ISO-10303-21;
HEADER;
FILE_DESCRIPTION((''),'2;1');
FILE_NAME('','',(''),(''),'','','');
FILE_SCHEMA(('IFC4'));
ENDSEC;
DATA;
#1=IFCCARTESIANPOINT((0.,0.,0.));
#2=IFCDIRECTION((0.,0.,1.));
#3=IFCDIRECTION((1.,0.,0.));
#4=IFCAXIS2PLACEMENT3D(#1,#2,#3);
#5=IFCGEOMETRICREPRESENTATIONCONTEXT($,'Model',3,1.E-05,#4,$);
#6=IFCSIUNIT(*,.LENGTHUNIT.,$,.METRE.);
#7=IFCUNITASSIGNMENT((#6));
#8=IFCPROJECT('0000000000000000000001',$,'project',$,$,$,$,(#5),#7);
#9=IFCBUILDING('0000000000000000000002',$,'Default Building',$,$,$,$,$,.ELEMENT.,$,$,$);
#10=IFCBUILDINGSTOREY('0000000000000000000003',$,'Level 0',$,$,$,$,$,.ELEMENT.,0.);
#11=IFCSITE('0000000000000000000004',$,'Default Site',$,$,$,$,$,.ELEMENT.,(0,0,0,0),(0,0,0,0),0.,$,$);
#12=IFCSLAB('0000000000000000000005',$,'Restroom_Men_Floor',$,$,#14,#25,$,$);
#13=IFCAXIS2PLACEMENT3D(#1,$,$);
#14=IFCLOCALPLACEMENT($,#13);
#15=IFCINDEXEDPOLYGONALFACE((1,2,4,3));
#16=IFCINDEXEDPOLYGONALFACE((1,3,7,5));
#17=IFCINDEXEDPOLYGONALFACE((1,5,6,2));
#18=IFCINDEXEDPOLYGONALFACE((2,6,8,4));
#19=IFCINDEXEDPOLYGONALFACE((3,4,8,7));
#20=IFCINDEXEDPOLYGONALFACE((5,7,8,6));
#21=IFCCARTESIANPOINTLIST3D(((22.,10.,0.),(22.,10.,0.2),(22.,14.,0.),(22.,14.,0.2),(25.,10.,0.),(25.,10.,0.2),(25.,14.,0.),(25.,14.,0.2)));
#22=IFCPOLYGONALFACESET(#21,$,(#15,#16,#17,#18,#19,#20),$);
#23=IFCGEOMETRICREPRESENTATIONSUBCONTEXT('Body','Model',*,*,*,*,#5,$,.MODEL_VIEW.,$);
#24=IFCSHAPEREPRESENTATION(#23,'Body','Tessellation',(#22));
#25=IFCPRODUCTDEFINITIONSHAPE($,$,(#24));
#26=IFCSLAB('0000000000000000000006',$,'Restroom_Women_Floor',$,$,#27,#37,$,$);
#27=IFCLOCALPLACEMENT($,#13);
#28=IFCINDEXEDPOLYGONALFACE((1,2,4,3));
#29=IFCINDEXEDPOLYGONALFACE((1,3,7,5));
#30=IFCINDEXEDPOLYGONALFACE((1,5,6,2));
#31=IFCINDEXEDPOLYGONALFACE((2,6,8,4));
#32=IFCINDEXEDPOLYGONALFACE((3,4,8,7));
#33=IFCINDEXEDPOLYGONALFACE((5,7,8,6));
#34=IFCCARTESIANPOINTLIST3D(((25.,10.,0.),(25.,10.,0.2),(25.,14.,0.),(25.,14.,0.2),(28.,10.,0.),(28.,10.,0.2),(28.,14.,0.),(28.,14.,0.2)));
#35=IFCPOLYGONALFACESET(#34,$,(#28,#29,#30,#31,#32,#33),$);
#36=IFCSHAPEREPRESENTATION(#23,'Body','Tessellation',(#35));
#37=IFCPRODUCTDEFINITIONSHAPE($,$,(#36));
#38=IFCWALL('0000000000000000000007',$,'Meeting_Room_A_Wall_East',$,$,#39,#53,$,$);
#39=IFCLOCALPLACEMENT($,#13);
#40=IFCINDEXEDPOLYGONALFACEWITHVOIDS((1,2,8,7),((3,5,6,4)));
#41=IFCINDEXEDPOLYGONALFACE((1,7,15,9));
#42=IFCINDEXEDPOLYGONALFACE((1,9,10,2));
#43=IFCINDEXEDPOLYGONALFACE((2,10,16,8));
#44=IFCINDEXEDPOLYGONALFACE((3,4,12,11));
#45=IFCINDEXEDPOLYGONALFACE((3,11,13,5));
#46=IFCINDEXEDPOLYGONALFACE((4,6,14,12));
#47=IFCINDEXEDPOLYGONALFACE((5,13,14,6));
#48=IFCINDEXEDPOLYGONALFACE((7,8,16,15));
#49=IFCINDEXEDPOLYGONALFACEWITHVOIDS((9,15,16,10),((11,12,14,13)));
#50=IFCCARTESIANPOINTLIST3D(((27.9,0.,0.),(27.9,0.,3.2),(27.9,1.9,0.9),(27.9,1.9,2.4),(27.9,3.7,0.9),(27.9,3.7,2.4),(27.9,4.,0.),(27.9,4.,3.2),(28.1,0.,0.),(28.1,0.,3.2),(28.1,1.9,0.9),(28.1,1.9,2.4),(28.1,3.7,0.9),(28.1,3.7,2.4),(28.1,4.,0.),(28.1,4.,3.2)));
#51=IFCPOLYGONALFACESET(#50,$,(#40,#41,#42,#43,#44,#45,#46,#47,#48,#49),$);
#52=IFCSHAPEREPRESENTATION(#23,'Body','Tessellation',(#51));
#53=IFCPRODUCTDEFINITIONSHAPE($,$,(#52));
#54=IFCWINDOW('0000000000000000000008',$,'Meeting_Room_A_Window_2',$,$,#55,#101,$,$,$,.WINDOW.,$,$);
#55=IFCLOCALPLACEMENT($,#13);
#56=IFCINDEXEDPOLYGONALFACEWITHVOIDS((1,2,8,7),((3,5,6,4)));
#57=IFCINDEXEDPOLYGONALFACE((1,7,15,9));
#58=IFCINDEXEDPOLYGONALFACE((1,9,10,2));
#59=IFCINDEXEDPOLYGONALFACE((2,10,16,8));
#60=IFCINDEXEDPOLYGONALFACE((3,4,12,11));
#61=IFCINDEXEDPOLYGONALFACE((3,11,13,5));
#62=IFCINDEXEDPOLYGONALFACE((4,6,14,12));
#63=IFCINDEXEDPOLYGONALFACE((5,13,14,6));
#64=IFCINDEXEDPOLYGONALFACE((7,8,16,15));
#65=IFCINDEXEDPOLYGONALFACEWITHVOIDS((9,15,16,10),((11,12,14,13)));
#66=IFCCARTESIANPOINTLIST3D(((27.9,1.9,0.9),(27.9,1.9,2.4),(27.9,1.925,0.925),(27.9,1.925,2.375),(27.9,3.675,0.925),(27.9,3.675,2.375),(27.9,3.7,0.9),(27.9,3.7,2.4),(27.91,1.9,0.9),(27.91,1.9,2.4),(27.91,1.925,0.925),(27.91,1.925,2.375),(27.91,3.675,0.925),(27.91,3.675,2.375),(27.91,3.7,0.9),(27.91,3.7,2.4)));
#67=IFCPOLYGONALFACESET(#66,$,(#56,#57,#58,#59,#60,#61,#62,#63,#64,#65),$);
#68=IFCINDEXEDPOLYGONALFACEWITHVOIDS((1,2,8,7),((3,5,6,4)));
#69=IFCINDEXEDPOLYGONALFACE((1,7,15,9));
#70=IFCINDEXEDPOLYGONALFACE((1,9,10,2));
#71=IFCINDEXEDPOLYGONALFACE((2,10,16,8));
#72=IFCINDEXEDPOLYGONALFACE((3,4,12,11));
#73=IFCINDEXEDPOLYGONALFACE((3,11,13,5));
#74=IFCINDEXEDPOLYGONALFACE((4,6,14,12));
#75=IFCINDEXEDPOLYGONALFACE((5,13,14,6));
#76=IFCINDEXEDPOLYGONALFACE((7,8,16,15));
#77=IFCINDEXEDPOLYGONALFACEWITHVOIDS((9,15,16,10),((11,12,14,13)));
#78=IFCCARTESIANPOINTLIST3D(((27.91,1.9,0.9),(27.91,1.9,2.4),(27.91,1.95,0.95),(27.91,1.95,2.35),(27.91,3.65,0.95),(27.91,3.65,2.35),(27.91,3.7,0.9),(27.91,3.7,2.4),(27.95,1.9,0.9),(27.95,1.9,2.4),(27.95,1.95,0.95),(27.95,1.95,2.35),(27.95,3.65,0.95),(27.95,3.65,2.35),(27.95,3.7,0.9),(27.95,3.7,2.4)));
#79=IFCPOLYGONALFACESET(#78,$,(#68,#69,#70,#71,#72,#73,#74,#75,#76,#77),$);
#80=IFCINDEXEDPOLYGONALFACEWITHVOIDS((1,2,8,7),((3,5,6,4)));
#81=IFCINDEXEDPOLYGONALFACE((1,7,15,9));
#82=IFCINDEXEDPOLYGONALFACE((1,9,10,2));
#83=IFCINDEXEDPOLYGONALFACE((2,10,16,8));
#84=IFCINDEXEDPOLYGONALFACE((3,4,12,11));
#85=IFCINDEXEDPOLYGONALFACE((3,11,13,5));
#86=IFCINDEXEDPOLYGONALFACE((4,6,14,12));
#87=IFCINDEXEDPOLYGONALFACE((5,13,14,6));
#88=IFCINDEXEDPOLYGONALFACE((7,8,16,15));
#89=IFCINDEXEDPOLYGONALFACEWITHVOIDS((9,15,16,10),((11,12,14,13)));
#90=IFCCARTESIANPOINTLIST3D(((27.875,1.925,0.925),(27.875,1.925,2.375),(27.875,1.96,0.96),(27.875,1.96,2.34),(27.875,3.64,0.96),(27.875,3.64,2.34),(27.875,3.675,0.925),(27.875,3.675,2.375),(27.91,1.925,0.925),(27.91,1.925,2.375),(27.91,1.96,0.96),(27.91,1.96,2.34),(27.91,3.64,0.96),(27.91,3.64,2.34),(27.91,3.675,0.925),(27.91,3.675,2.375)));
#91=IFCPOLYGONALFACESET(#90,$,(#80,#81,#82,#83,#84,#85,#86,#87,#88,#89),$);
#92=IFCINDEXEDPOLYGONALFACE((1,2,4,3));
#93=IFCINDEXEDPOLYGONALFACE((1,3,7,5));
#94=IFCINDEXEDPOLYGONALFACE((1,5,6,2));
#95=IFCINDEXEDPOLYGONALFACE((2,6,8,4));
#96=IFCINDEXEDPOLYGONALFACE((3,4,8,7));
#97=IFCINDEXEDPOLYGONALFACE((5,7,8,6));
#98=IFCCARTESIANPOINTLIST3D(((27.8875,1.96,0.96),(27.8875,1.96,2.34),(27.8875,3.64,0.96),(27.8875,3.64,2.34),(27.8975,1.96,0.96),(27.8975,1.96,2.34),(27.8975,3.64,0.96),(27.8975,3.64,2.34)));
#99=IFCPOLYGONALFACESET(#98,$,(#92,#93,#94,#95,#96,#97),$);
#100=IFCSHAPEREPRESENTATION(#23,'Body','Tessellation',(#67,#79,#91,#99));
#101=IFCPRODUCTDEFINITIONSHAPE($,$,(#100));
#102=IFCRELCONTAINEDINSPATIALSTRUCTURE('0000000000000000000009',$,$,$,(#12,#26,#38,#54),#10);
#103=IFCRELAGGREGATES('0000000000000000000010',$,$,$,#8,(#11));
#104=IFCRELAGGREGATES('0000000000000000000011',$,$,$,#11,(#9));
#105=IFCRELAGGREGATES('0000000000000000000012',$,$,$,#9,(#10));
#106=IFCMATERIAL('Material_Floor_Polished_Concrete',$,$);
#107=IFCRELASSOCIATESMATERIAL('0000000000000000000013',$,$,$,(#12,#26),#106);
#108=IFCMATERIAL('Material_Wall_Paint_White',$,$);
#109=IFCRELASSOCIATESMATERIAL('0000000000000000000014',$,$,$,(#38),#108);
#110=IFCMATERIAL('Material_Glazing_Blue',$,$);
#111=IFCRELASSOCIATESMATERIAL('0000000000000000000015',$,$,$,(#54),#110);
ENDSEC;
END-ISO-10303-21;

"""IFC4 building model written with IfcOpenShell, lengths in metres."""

from ifc_helpers import new_model, si_unit, frame, origin_with_axes, place, context, subcontext, project, spatial, line, indexed_curve, outline, extrude, material, element, fill, save


model = new_model("IFC4")

# Units and contexts
model_context = context("Model", 3, precision=1e-05, world=origin_with_axes())
body_context = subcontext(model_context, "Body", "Model", "MODEL_VIEW")
ifc_project = project(units=[si_unit("LENGTHUNIT", "METRE")], contexts=[model_context])

# Site, building, storey
site = spatial("IfcSite", under=ifc_project, Name="Default Site", CompositionType="ELEMENT", RefLatitude=(0, 0, 0, 0), RefLongitude=(0, 0, 0, 0), RefElevation=0.0)
building = spatial("IfcBuilding", under=site, Name="Default Building", CompositionType="ELEMENT")
storey = spatial("IfcBuildingStorey", under=building, Name="Level 0", CompositionType="ELEMENT", Elevation=0.0)

# Slabs
ifc_material_1 = material(Name="Material_Floor_Polished_Concrete")
for number, where, z_axis, x_axis, name in (
    (1, (22.0, 10.0, 0.0), (0.0, 0.0, 1.0), (1.0, 0.0, 0.0), "Restroom_Men_Floor"),
    (2, (25.0, 10.0, 0.0), (0.0, 0.0, 1.0), (1.0, 0.0, 0.0), "Restroom_Women_Floor"),
):
    element("IfcSlab", number, at=place(None, frame(where, z_axis=z_axis, x_axis=x_axis)), inside=storey, material=ifc_material_1, Name=name, context=body_context, shape_type="SweptSolid", body=[
        extrude(outline(indexed_curve([(0.0, 0.0), (3.0, 0.0), (3.0, 4.0), (0.0, 4.0)])), None, (0.0, 0.0, 1.0), 0.2),
    ])

# Wall, opening, window
ifc_material_2 = material(Name="Material_Wall_Paint_White")
wall_1_placement = place(None, frame((28.0, 0.0, 0.0), z_axis=(0.0, 0.0, 1.0), x_axis=(0.0, 1.0, 0.0)))
wall_1 = element("IfcWall", 3, at=wall_1_placement, inside=storey, material=ifc_material_2, Name="Meeting_Room_A_Wall_East", context=body_context, shape_type="SweptSolid", body=[
    extrude(outline(indexed_curve([(0.0, 0.0), (0.0, 0.2), (4.0, 0.2), (4.0, 0.0), (0.0, 0.0)], self_intersect=False)), frame((0.0, -0.1, 0.0), z_axis=(0.0, 0.0, 1.0), x_axis=(1.0, 0.0, 0.0)), (0.0, 0.0, 1.0), 3.2),
])
opening_1_placement = place(wall_1_placement, frame((1.9, -0.5, 0.9), z_axis=(0.0, 0.0, 1.0), x_axis=(1.0, 0.0, 0.0)))
opening_1 = element("IfcOpeningElement", 4, at=opening_1_placement, inside=storey, cuts=wall_1, PredefinedType="OPENING", context=body_context, shape_type="SweptSolid", body=[
    extrude(outline(indexed_curve([(0.0, 0.0), (0.0, 1.0), (1.8, 1.0), (1.8, 0.0), (0.0, 0.0)], self_intersect=False)), origin_with_axes(), (0.0, 0.0, 1.0), 1.5),
])
ifc_material_3 = material(Name="Material_Glazing_Blue")
window_1_placement = place(None, frame((28.0, 1.9, 0.9), z_axis=(0.0, 0.0, 1.0), x_axis=(0.0, 1.0, 0.0)))
window_1 = element("IfcWindow", 5, at=window_1_placement, inside=storey, material=ifc_material_3, Name="Meeting_Room_A_Window_2", PredefinedType="WINDOW", context=body_context, shape_type="SweptSolid", body=[
    extrude(outline(indexed_curve([(0.0, 0.0), (1.8, 0.0), (1.8, 1.5), (0.0, 1.5)], segments=[line(1, 2, 3, 4, 1)]), holes=[indexed_curve([(0.025, 0.025), (1.775, 0.025), (1.775, 1.475), (0.025, 1.475)], segments=[line(1, 2, 3, 4, 1)])]), frame((0.0, 0.09, 0.0), z_axis=(0.0, -1.0, 0.0), x_axis=(1.0, 0.0, 0.0)), (0.0, 0.0, -1.0), 0.01),
    extrude(outline(indexed_curve([(0.0, 0.0), (1.8, 0.0), (1.8, 1.5), (0.0, 1.5)], segments=[line(1, 2, 3, 4, 1)]), holes=[indexed_curve([(0.05, 0.05), (1.75, 0.05), (1.75, 1.45), (0.05, 1.45)], segments=[line(1, 2, 3, 4, 1)])]), frame((0.0, 0.05, 0.0), z_axis=(0.0, -1.0, 0.0), x_axis=(1.0, 0.0, 0.0)), (0.0, 0.0, -1.0), 0.04),
    extrude(outline(indexed_curve([(0.0, 0.0), (1.75, 0.0), (1.75, 1.45), (0.0, 1.45)], segments=[line(1, 2, 3, 4, 1)]), holes=[indexed_curve([(0.035, 0.035), (1.715, 0.035), (1.715, 1.415), (0.035, 1.415)], segments=[line(1, 2, 3, 4, 1)])]), frame((0.025, 0.09, 0.025), z_axis=(0.0, -1.0, 0.0), x_axis=(1.0, 0.0, 0.0)), (0.0, 0.0, -1.0), 0.035),
    extrude(outline(indexed_curve([(0.035, 0.035), (1.715, 0.035), (1.715, 1.415), (0.035, 1.415)], segments=[line(1, 2, 3, 4, 1)])), frame((0.025, 0.1025, 0.025), z_axis=(0.0, -1.0, 0.0), x_axis=(1.0, 0.0, 0.0)), (0.0, 0.0, -1.0), 0.01),
])
fill(opening_1, window_1)

save(model, "model.ifc")
